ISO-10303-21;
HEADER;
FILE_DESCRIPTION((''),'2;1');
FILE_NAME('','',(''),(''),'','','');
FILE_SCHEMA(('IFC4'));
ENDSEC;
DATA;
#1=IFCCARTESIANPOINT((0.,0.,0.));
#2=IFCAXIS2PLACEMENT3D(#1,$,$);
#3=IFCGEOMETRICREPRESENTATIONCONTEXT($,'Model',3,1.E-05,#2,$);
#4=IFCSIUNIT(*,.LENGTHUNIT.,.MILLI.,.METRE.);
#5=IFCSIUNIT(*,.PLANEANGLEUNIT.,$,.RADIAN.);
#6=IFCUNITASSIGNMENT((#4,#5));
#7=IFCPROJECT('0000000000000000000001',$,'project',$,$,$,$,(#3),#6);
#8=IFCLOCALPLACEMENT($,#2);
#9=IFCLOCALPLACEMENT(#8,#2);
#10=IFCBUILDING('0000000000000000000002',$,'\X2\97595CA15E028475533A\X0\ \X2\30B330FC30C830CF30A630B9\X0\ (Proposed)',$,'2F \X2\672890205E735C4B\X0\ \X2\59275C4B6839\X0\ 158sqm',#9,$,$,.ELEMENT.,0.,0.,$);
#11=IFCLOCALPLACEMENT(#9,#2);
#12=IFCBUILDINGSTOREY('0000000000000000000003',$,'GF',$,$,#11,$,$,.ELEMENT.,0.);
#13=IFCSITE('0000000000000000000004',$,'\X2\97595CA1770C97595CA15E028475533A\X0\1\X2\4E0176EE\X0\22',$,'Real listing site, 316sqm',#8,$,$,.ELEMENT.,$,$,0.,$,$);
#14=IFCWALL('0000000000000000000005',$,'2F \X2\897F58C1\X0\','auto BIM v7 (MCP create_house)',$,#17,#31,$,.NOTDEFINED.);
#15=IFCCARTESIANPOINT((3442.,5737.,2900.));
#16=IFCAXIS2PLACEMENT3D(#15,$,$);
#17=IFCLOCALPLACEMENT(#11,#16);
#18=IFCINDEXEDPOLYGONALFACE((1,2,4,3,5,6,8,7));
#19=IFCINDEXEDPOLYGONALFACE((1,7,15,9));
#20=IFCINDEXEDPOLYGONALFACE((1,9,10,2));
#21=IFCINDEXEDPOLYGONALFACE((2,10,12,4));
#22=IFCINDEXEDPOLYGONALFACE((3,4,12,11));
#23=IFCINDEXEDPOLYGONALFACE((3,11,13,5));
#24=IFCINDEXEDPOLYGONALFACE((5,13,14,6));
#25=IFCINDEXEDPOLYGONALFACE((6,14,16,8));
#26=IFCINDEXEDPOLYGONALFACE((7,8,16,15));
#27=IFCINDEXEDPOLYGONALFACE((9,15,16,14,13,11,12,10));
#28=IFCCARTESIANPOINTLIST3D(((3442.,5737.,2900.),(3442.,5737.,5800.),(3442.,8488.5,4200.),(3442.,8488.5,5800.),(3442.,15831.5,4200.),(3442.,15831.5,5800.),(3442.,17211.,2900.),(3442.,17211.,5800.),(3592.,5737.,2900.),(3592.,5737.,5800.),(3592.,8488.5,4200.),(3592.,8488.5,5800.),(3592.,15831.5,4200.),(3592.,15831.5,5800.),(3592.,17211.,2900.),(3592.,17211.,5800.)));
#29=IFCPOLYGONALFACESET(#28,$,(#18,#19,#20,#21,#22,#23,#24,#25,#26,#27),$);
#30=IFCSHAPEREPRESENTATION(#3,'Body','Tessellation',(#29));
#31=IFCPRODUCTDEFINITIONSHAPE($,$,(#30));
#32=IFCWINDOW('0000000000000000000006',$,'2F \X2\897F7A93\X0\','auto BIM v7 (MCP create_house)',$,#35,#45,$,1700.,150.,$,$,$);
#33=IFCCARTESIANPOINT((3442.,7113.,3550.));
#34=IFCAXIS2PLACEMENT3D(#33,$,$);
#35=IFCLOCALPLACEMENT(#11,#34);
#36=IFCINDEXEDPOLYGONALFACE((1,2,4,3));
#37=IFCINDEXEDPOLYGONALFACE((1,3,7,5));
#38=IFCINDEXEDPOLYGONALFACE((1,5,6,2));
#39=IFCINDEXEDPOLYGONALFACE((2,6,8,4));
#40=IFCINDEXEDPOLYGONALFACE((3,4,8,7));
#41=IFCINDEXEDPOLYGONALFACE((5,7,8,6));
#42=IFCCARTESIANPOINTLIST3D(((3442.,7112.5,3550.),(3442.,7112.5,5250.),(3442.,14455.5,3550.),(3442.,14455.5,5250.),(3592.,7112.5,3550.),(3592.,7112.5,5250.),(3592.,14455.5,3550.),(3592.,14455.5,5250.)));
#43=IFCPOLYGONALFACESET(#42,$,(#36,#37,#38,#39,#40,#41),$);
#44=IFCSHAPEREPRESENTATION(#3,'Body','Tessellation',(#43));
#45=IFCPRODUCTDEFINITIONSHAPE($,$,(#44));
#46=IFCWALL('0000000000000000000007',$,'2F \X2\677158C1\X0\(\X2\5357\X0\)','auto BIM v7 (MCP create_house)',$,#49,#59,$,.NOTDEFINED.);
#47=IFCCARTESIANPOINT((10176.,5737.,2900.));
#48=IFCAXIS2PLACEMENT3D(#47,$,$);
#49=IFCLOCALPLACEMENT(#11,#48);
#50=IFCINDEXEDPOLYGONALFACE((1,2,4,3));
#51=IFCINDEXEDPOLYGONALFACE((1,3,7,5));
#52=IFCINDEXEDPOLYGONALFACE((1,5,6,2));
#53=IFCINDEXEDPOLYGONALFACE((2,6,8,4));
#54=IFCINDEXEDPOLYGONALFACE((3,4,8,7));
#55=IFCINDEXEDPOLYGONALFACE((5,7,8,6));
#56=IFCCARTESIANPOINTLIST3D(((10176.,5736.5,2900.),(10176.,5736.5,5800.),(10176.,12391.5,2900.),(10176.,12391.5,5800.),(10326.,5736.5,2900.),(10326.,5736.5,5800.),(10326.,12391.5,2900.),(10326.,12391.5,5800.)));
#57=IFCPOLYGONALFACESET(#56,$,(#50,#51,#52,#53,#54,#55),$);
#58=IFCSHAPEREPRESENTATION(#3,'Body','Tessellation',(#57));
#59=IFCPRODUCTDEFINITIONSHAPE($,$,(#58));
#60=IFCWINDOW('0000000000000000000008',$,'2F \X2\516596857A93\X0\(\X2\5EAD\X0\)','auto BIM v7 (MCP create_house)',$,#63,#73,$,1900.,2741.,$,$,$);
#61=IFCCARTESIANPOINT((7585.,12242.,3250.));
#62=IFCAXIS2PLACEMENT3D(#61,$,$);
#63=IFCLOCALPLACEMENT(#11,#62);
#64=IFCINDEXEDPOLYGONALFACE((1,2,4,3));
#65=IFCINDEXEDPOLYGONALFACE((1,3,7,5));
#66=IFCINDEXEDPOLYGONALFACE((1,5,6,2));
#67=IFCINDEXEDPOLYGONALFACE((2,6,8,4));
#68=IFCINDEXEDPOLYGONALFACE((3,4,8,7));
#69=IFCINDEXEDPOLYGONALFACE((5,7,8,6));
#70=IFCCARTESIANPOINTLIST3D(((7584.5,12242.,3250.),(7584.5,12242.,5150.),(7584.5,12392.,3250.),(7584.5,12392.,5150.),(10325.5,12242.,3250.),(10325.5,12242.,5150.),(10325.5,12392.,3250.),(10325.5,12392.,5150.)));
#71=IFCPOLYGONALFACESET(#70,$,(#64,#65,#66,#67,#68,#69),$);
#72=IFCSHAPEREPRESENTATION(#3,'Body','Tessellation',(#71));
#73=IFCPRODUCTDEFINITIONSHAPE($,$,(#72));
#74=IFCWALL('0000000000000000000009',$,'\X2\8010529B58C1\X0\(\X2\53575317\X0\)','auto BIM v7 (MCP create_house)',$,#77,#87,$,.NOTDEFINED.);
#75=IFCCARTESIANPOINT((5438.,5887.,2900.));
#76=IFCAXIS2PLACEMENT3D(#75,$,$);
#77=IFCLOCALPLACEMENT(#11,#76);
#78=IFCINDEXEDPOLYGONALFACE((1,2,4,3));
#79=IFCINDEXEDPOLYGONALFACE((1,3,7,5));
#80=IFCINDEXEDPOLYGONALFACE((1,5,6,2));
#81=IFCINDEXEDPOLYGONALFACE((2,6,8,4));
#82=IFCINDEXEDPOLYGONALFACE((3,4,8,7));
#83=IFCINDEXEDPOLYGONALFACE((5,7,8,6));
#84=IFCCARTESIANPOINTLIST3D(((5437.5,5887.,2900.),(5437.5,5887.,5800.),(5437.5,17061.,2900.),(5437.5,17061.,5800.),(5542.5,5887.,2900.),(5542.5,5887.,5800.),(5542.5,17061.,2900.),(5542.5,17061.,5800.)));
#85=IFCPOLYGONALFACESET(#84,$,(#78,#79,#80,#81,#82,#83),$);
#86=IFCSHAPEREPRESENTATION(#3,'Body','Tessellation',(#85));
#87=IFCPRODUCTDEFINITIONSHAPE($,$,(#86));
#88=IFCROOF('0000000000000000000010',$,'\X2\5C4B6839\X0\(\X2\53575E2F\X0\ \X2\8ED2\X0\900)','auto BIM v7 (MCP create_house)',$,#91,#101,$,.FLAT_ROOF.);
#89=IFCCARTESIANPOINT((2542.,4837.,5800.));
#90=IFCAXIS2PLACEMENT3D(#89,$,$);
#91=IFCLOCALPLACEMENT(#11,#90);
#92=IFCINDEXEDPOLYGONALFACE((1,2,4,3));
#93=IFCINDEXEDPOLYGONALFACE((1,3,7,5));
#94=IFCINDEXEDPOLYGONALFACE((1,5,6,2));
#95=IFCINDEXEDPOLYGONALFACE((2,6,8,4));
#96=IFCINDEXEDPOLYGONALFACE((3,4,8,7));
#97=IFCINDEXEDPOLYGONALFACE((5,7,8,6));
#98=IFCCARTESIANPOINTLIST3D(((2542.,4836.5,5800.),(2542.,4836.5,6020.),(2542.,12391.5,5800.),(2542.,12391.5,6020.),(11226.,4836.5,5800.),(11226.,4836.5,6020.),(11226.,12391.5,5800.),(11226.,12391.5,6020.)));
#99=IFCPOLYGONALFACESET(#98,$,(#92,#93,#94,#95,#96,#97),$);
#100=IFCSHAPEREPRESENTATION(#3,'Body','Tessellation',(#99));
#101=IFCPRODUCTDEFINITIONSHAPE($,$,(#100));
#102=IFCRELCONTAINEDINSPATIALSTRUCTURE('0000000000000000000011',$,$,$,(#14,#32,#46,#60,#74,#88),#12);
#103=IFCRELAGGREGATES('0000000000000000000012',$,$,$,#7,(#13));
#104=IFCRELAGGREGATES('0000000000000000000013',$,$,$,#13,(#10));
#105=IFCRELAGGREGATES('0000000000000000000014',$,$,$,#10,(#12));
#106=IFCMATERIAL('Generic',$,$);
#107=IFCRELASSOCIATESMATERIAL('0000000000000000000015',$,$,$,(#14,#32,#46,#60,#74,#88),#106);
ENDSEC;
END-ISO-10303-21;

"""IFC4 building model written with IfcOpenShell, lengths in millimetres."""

from ifc_helpers import new_model, si_unit, frame, frame_2d, origin, place, context, project, spatial, rectangle, extrude, material, element, fill, save


model = new_model("IFC4")

# Units and contexts
model_context = context("Model", 3, precision=1e-05, world=origin())
ifc_project = project(units=[si_unit("LENGTHUNIT", "METRE", prefix="MILLI"), si_unit("PLANEANGLEUNIT", "RADIAN")], contexts=[model_context])

# Site, building, storey
site_placement = place(None, origin())
site = spatial("IfcSite", under=ifc_project, at=site_placement, Name="静岡県静岡市葵区1丁目22", ObjectType="Real listing site, 316sqm", CompositionType="ELEMENT", RefElevation=0.0)
building_placement = place(site_placement, origin())
building = spatial("IfcBuilding", under=site, at=building_placement, Name="静岡市葵区 コートハウス (Proposed)", ObjectType="2F 木造平屋 大屋根 158sqm", CompositionType="ELEMENT", ElevationOfRefHeight=0.0, ElevationOfTerrain=0.0)
storey_placement = place(building_placement, origin())
storey = spatial("IfcBuildingStorey", under=building, at=storey_placement, Name="GF", CompositionType="ELEMENT", Elevation=0.0)

# Shared definitions
ifc_material = material(Name="Generic")

# Walls, openings, windows
wall_1_placement = place(storey_placement, frame((3442.0, 5737.0, 2900.0)))
wall_1 = element("IfcWall", 1, at=wall_1_placement, inside=storey, material=ifc_material, Name="2F 西壁", Description="auto BIM v7 (MCP create_house)", PredefinedType="NOTDEFINED", context=model_context, shape_type="SweptSolid", body=[
    extrude(rectangle(XDim=150.0, YDim=11474.0, at=frame_2d((75.0, 5737.0))), frame((3442.0, 5737.0, 2900.0)), (0.0, 0.0, 1.0), 2900.0),
])
opening_1_placement = place(storey_placement, frame((3442.0, 7113.0, 3550.0)))
opening_1 = element("IfcOpeningElement", 2, at=opening_1_placement, cuts=wall_1, PredefinedType="NOTDEFINED", context=model_context, shape_type="SweptSolid", body=[
    extrude(rectangle(XDim=150.0, YDim=7343.0, at=frame_2d((75.0, 3671.0))), frame((3442.0, 7113.0, 3550.0)), (0.0, 0.0, 1.0), 1700.0),
])
window_1_placement = place(storey_placement, frame((3442.0, 7113.0, 3550.0)))
window_1 = element("IfcWindow", 3, at=window_1_placement, inside=storey, material=ifc_material, Name="2F 西窓", Description="auto BIM v7 (MCP create_house)", OverallHeight=1700.0, OverallWidth=150.0, context=model_context, shape_type="SweptSolid", body=[
    extrude(rectangle(XDim=150.0, YDim=7343.0, at=frame_2d((75.0, 3671.0))), frame((3442.0, 7113.0, 3550.0)), (0.0, 0.0, 1.0), 1700.0),
])
fill(opening_1, window_1)
wall_2_placement = place(storey_placement, frame((10176.0, 5737.0, 2900.0)))
wall_2 = element("IfcWall", 4, at=wall_2_placement, inside=storey, material=ifc_material, Name="2F 東壁(南)", Description="auto BIM v7 (MCP create_house)", PredefinedType="NOTDEFINED", context=model_context, shape_type="SweptSolid", body=[
    extrude(rectangle(XDim=150.0, YDim=6655.0, at=frame_2d((75.0, 3327.0))), frame((10176.0, 5737.0, 2900.0)), (0.0, 0.0, 1.0), 2900.0),
])
opening_2_placement = place(storey_placement, frame((7585.0, 12242.0, 3250.0)))
opening_2 = element("IfcOpeningElement", 5, at=opening_2_placement, cuts=wall_2, PredefinedType="NOTDEFINED", context=model_context, shape_type="SweptSolid", body=[
    extrude(rectangle(XDim=2741.0, YDim=150.0, at=frame_2d((1370.0, 75.0))), frame((7585.0, 12242.0, 3250.0)), (0.0, 0.0, 1.0), 1900.0),
])
window_2_placement = place(storey_placement, frame((7585.0, 12242.0, 3250.0)))
window_2 = element("IfcWindow", 6, at=window_2_placement, inside=storey, material=ifc_material, Name="2F 入隅窓(庭)", Description="auto BIM v7 (MCP create_house)", OverallHeight=1900.0, OverallWidth=2741.0, context=model_context, shape_type="SweptSolid", body=[
    extrude(rectangle(XDim=2741.0, YDim=150.0, at=frame_2d((1370.0, 75.0))), frame((7585.0, 12242.0, 3250.0)), (0.0, 0.0, 1.0), 1900.0),
])
fill(opening_2, window_2)

# Wall
wall_3_placement = place(storey_placement, frame((5438.0, 5887.0, 2900.0)))
element("IfcWall", 7, at=wall_3_placement, inside=storey, material=ifc_material, Name="耐力壁(南北)", Description="auto BIM v7 (MCP create_house)", PredefinedType="NOTDEFINED", context=model_context, shape_type="SweptSolid", body=[
    extrude(rectangle(XDim=105.0, YDim=11174.0, at=frame_2d((52.0, 5587.0))), frame((5438.0, 5887.0, 2900.0)), (0.0, 0.0, 1.0), 2900.0),
])

# Roof
for number, where, name in (
    (8, (2542.0, 4837.0, 5800.0), "屋根(南帯 軒900)"),
):
    element("IfcRoof", number, at=place(storey_placement, frame(where)), inside=storey, material=ifc_material, Name=name, Description="auto BIM v7 (MCP create_house)", PredefinedType="FLAT_ROOF", context=model_context, shape_type="SweptSolid", body=[
        extrude(rectangle(XDim=8684.0, YDim=7555.0, at=frame_2d((4342.0, 3777.0))), frame((2542.0, 4837.0, 5800.0)), (0.0, 0.0, 1.0), 220.0),
    ])

save(model, "model.ifc")
